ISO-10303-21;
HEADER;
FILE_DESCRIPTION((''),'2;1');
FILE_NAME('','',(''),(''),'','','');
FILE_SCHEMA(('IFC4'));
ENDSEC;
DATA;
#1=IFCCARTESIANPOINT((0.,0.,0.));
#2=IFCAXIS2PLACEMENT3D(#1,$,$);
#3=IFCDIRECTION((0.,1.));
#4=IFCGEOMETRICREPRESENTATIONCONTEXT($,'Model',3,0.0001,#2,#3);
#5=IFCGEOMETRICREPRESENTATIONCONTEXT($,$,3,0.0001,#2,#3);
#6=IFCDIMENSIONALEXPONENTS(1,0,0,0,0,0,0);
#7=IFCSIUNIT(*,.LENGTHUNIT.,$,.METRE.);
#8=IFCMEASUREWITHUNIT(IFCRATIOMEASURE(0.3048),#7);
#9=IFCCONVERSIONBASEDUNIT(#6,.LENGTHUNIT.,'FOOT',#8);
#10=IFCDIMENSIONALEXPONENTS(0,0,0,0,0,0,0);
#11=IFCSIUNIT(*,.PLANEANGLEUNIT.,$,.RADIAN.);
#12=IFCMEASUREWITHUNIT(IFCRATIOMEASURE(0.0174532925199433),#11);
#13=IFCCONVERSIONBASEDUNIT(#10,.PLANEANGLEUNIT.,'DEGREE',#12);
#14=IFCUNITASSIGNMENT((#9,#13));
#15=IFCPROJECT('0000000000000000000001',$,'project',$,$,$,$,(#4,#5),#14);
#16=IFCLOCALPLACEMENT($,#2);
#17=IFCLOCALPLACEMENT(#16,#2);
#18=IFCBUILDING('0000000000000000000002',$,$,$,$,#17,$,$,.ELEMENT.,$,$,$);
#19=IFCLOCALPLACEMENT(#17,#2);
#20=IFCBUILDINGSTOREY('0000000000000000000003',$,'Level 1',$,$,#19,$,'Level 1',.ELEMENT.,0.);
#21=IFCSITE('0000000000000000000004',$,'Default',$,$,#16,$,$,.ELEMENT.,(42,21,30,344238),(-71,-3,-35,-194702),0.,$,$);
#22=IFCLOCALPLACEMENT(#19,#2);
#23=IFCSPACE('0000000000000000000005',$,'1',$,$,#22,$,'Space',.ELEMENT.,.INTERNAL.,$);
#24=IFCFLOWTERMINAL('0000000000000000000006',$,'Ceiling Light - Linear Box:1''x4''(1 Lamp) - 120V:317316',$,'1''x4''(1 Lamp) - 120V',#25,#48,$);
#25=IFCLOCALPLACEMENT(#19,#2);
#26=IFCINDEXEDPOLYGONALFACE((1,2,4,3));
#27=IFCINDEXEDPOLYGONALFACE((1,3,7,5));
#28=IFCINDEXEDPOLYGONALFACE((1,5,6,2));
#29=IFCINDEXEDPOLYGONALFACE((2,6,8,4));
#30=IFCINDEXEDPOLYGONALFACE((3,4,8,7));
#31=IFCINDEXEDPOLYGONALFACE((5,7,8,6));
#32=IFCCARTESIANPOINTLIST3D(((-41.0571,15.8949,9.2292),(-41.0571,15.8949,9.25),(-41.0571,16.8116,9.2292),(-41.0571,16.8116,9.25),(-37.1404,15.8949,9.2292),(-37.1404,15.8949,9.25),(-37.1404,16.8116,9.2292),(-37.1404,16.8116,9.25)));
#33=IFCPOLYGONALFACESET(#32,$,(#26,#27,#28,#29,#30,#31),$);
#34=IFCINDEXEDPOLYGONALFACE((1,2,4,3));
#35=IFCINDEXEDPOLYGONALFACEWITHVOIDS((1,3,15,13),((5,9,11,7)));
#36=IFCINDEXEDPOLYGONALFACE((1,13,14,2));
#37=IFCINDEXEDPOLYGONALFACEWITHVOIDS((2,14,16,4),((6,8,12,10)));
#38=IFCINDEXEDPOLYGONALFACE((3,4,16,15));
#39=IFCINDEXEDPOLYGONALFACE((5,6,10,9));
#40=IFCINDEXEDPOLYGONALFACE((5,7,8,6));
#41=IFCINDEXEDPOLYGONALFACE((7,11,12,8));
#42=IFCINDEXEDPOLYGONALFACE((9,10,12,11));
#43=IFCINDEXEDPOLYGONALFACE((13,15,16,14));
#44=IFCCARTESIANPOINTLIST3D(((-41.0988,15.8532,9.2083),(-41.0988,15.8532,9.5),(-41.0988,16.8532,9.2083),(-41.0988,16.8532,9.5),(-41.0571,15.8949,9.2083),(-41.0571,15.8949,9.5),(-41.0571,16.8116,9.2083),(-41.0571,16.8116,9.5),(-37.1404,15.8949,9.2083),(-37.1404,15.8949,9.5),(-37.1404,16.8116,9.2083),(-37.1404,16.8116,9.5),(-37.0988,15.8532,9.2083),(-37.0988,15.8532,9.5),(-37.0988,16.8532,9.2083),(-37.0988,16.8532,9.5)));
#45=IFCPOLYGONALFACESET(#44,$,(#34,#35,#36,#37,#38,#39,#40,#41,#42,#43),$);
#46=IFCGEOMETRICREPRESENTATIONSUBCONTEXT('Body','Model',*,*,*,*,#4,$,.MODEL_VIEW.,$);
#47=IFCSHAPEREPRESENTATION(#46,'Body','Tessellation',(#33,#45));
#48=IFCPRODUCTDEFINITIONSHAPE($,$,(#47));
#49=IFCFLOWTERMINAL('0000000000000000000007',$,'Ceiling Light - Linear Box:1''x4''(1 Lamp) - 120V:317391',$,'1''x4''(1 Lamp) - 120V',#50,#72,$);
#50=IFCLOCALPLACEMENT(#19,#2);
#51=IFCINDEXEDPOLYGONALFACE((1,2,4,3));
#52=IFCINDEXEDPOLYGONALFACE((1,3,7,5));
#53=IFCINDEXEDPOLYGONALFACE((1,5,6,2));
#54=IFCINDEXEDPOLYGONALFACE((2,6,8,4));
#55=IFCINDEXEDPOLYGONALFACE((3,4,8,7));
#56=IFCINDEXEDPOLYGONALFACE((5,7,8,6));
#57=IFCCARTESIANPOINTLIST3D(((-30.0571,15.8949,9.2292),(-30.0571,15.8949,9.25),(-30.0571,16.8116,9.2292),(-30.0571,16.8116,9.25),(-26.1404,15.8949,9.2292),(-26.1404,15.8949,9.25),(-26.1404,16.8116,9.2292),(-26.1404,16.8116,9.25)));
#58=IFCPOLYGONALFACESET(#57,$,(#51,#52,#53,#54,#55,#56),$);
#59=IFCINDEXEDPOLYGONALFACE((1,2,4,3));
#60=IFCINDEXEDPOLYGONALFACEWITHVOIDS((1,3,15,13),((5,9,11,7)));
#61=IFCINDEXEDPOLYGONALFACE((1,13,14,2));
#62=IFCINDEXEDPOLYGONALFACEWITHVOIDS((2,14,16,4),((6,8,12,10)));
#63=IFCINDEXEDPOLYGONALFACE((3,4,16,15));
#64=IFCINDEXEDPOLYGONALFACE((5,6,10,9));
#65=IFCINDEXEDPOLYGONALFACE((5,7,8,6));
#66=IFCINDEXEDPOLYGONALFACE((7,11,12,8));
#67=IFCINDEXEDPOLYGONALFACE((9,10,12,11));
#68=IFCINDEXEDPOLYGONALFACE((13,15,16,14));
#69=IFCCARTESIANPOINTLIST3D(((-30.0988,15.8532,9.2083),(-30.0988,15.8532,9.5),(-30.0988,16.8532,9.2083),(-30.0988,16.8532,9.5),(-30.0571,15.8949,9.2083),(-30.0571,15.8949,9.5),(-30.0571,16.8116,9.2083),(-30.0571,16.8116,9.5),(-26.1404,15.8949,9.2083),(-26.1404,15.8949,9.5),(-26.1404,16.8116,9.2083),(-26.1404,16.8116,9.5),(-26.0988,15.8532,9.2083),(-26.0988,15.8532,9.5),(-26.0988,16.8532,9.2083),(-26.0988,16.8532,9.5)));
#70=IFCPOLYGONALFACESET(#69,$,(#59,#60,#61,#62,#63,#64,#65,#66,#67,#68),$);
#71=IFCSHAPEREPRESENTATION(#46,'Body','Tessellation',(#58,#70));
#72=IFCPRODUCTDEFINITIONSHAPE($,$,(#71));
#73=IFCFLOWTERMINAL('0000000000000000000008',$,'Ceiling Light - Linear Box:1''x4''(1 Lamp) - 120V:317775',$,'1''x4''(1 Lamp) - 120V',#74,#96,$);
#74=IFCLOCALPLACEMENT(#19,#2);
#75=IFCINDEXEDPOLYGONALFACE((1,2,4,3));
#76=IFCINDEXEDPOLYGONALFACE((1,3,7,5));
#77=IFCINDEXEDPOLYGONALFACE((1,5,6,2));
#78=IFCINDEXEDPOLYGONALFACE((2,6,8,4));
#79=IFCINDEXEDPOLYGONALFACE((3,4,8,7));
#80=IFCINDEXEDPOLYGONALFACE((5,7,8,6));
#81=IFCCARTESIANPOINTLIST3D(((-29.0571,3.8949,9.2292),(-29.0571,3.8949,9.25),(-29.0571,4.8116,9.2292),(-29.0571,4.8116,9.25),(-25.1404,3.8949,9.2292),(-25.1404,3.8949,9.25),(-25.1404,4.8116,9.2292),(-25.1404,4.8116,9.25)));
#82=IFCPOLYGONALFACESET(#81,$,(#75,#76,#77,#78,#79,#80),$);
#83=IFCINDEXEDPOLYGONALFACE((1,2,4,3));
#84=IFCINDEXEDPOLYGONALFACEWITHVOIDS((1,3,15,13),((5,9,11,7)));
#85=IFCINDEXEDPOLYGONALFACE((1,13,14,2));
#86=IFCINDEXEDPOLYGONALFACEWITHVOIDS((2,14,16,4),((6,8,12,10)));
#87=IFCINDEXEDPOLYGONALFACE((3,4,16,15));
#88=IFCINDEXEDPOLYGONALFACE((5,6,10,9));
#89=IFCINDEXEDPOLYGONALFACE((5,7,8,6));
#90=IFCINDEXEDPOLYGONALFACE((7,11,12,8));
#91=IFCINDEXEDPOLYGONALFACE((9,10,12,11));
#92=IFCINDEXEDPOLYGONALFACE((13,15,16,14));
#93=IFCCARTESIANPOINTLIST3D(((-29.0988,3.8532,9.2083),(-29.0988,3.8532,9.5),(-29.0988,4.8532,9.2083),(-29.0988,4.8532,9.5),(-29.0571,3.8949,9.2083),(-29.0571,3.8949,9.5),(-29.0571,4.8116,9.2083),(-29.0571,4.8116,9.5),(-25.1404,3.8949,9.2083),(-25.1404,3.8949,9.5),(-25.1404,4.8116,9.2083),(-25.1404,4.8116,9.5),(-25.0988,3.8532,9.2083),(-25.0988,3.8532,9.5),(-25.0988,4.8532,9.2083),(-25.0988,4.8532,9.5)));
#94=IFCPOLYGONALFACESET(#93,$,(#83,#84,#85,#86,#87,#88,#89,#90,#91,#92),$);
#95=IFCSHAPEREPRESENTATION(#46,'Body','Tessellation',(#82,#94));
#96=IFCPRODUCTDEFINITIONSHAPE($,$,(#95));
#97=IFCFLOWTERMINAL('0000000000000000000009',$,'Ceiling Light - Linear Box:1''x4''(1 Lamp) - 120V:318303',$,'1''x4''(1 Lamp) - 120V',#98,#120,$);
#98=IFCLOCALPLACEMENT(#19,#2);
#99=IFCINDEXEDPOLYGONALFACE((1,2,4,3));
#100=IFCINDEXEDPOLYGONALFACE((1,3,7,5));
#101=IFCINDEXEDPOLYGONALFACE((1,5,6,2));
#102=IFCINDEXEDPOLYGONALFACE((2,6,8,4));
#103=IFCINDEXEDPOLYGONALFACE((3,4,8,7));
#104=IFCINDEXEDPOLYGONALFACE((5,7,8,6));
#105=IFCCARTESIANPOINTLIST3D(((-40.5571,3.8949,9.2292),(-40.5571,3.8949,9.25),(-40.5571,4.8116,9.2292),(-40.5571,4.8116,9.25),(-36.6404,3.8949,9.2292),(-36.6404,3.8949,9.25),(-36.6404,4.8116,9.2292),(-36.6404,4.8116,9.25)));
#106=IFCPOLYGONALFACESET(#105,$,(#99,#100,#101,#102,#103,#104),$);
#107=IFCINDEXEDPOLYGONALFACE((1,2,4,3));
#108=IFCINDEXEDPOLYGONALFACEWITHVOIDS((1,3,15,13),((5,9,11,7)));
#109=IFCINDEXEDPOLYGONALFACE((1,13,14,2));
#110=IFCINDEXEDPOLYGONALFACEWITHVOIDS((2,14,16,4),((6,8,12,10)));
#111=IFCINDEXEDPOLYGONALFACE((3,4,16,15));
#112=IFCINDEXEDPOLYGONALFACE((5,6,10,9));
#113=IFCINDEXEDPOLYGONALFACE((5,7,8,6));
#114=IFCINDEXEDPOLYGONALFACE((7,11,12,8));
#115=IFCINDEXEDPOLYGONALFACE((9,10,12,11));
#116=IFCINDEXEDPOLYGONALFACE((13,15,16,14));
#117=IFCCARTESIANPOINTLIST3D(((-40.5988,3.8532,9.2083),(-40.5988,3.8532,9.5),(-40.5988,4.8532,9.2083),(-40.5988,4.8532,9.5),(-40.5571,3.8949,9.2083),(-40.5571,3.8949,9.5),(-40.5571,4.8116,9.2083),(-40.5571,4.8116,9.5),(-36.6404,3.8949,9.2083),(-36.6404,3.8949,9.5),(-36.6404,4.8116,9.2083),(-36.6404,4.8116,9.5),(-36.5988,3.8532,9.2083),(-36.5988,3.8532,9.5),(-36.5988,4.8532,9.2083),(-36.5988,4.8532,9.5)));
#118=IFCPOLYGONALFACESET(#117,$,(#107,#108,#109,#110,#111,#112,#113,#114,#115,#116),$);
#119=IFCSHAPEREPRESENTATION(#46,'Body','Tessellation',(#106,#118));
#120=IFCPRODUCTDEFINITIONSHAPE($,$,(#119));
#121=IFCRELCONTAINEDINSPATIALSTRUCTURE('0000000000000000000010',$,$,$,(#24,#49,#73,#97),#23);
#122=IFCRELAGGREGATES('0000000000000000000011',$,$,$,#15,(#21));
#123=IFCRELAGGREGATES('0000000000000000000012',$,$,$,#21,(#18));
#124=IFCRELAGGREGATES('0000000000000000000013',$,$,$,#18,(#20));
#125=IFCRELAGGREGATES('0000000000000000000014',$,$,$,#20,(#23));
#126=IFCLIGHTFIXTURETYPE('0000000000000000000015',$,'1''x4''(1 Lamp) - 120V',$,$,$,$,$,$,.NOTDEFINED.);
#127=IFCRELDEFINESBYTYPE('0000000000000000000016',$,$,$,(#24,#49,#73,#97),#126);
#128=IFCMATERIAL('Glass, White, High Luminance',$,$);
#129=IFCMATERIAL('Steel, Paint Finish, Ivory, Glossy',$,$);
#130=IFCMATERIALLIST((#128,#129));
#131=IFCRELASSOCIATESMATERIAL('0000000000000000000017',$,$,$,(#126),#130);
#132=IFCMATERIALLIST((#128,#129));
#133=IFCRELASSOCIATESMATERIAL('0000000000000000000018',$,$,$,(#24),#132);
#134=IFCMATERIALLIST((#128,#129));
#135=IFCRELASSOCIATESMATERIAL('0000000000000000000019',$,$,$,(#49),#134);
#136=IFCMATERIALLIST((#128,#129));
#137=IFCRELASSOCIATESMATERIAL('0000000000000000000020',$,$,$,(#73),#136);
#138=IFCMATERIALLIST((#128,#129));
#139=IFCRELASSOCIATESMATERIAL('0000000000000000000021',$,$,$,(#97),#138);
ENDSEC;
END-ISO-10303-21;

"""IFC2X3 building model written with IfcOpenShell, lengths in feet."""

from ifc_helpers import new_model, entity, si_unit, converted_unit, direction, frame, origin, origin_2d_with_axis, place, context, subcontext, project, spatial, polyline, rectangle, outline, extrude, source, transform, mapped, material, material_list, type_object, type_shapes, element, save


model = new_model("IFC2X3")

# Units and contexts
model_context = context("Model", 3, precision=0.0001, world=origin(), true_north=direction((0.0, 1.0)))
context_of_model = context(None, 3, precision=0.0001, world=origin(), true_north=direction((0.0, 1.0)))
body_context = subcontext(model_context, "Body", "Model", "MODEL_VIEW")
ifc_project = project(units=[converted_unit("LENGTHUNIT", "FOOT", entity("IfcRatioMeasure", 0.3048), si_unit("LENGTHUNIT", "METRE"), dimensions=[1, 0, 0, 0, 0, 0, 0]), converted_unit("PLANEANGLEUNIT", "DEGREE", entity("IfcRatioMeasure", 0.0174532925199433), si_unit("PLANEANGLEUNIT", "RADIAN"), dimensions=[0, 0, 0, 0, 0, 0, 0])], contexts=[model_context, context_of_model])

# Site, building, storey
site_placement = place(None, origin())
site = spatial("IfcSite", under=ifc_project, at=site_placement, Name="Default", CompositionType="ELEMENT", RefLatitude=(42, 21, 30, 344238), RefLongitude=(-71, -3, -35, -194702), RefElevation=0.0)
building_placement = place(site_placement, origin())
building = spatial("IfcBuilding", under=site, at=building_placement, CompositionType="ELEMENT")
storey_placement = place(building_placement, origin())
storey = spatial("IfcBuildingStorey", under=building, at=storey_placement, Name="Level 1", LongName="Level 1", CompositionType="ELEMENT", Elevation=0.0)

# Shared definitions
space_placement = place(storey_placement, origin())
space = spatial("IfcSpace", under=storey, at=space_placement, Name="1", LongName="Space", CompositionType="ELEMENT", InteriorOrExteriorSpace="INTERNAL")

# Flow terminals
ifc_material_1 = material(Name="Glass, White, High Luminance")
ifc_material_2 = material(Name="Steel, Paint Finish, Ivory, Glossy")
ifc_material_list_1 = material_list([ifc_material_1, ifc_material_2])
ifc_material_list_2 = material_list([ifc_material_1, ifc_material_2])
light_fixture_type_1 = type_object("IfcLightFixtureType", Name="1'x4'(1 Lamp) - 120V", PredefinedType="NOTDEFINED", material=ifc_material_list_2)
shared_shape_1 = source(origin(), body_context, "Body", "SweptSolid", [
    extrude(rectangle(XDim=3.9167, YDim=0.9167, at=origin_2d_with_axis()), frame((0.0, 0.0, 7.7292), z_axis=(0.0, 0.0, 1.0), x_axis=(-1.0, 0.0, 0.0)), (0.0, 0.0, 1.0), 0.0208),
    extrude(outline(polyline([(-2.0, -0.5), (2.0, -0.5), (2.0, 0.5), (-2.0, 0.5), (-2.0, -0.5)]), holes=[polyline([(-1.9583, -0.4583), (-1.9583, 0.4583), (1.9583, 0.4583), (1.9583, -0.4583), (-1.9583, -0.4583)])]), frame((0.0, 0.0, 7.7083), z_axis=(0.0, 0.0, 1.0), x_axis=(-1.0, 0.0, 0.0)), (0.0, 0.0, 1.0), 0.2917),
])
type_shapes(light_fixture_type_1, [shared_shape_1])
flow_terminal_1_placement = place(space_placement, frame((-39.0988, 16.3532, 1.5)))
element("IfcFlowTerminal", 1, at=flow_terminal_1_placement, inside=space, type_object=light_fixture_type_1, material=ifc_material_list_1, Name="Ceiling Light - Linear Box:1'x4'(1 Lamp) - 120V:317316", ObjectType="1'x4'(1 Lamp) - 120V", context=body_context, shape_type="MappedRepresentation", body=[
    mapped(shared_shape_1, transform((0.0, 0.0, 0.0), scale=1.0)),
])
ifc_material_list_3 = material_list([ifc_material_1, ifc_material_2])
flow_terminal_2_placement = place(space_placement, frame((-28.0988, 16.3532, 1.5)))
element("IfcFlowTerminal", 2, at=flow_terminal_2_placement, inside=space, type_object=light_fixture_type_1, material=ifc_material_list_3, Name="Ceiling Light - Linear Box:1'x4'(1 Lamp) - 120V:317391", ObjectType="1'x4'(1 Lamp) - 120V", context=body_context, shape_type="MappedRepresentation", body=[
    mapped(shared_shape_1, transform((0.0, 0.0, 0.0), scale=1.0)),
])
ifc_material_list_4 = material_list([ifc_material_1, ifc_material_2])
flow_terminal_3_placement = place(space_placement, frame((-27.0988, 4.3532, 1.5)))
element("IfcFlowTerminal", 3, at=flow_terminal_3_placement, inside=space, type_object=light_fixture_type_1, material=ifc_material_list_4, Name="Ceiling Light - Linear Box:1'x4'(1 Lamp) - 120V:317775", ObjectType="1'x4'(1 Lamp) - 120V", context=body_context, shape_type="MappedRepresentation", body=[
    mapped(shared_shape_1, transform((0.0, 0.0, 0.0), scale=1.0)),
])
ifc_material_list_5 = material_list([ifc_material_1, ifc_material_2])
flow_terminal_4_placement = place(space_placement, frame((-38.5988, 4.3532, 1.5)))
element("IfcFlowTerminal", 4, at=flow_terminal_4_placement, inside=space, type_object=light_fixture_type_1, material=ifc_material_list_5, Name="Ceiling Light - Linear Box:1'x4'(1 Lamp) - 120V:318303", ObjectType="1'x4'(1 Lamp) - 120V", context=body_context, shape_type="MappedRepresentation", body=[
    mapped(shared_shape_1, transform((0.0, 0.0, 0.0), scale=1.0)),
])

save(model, "model.ifc")
